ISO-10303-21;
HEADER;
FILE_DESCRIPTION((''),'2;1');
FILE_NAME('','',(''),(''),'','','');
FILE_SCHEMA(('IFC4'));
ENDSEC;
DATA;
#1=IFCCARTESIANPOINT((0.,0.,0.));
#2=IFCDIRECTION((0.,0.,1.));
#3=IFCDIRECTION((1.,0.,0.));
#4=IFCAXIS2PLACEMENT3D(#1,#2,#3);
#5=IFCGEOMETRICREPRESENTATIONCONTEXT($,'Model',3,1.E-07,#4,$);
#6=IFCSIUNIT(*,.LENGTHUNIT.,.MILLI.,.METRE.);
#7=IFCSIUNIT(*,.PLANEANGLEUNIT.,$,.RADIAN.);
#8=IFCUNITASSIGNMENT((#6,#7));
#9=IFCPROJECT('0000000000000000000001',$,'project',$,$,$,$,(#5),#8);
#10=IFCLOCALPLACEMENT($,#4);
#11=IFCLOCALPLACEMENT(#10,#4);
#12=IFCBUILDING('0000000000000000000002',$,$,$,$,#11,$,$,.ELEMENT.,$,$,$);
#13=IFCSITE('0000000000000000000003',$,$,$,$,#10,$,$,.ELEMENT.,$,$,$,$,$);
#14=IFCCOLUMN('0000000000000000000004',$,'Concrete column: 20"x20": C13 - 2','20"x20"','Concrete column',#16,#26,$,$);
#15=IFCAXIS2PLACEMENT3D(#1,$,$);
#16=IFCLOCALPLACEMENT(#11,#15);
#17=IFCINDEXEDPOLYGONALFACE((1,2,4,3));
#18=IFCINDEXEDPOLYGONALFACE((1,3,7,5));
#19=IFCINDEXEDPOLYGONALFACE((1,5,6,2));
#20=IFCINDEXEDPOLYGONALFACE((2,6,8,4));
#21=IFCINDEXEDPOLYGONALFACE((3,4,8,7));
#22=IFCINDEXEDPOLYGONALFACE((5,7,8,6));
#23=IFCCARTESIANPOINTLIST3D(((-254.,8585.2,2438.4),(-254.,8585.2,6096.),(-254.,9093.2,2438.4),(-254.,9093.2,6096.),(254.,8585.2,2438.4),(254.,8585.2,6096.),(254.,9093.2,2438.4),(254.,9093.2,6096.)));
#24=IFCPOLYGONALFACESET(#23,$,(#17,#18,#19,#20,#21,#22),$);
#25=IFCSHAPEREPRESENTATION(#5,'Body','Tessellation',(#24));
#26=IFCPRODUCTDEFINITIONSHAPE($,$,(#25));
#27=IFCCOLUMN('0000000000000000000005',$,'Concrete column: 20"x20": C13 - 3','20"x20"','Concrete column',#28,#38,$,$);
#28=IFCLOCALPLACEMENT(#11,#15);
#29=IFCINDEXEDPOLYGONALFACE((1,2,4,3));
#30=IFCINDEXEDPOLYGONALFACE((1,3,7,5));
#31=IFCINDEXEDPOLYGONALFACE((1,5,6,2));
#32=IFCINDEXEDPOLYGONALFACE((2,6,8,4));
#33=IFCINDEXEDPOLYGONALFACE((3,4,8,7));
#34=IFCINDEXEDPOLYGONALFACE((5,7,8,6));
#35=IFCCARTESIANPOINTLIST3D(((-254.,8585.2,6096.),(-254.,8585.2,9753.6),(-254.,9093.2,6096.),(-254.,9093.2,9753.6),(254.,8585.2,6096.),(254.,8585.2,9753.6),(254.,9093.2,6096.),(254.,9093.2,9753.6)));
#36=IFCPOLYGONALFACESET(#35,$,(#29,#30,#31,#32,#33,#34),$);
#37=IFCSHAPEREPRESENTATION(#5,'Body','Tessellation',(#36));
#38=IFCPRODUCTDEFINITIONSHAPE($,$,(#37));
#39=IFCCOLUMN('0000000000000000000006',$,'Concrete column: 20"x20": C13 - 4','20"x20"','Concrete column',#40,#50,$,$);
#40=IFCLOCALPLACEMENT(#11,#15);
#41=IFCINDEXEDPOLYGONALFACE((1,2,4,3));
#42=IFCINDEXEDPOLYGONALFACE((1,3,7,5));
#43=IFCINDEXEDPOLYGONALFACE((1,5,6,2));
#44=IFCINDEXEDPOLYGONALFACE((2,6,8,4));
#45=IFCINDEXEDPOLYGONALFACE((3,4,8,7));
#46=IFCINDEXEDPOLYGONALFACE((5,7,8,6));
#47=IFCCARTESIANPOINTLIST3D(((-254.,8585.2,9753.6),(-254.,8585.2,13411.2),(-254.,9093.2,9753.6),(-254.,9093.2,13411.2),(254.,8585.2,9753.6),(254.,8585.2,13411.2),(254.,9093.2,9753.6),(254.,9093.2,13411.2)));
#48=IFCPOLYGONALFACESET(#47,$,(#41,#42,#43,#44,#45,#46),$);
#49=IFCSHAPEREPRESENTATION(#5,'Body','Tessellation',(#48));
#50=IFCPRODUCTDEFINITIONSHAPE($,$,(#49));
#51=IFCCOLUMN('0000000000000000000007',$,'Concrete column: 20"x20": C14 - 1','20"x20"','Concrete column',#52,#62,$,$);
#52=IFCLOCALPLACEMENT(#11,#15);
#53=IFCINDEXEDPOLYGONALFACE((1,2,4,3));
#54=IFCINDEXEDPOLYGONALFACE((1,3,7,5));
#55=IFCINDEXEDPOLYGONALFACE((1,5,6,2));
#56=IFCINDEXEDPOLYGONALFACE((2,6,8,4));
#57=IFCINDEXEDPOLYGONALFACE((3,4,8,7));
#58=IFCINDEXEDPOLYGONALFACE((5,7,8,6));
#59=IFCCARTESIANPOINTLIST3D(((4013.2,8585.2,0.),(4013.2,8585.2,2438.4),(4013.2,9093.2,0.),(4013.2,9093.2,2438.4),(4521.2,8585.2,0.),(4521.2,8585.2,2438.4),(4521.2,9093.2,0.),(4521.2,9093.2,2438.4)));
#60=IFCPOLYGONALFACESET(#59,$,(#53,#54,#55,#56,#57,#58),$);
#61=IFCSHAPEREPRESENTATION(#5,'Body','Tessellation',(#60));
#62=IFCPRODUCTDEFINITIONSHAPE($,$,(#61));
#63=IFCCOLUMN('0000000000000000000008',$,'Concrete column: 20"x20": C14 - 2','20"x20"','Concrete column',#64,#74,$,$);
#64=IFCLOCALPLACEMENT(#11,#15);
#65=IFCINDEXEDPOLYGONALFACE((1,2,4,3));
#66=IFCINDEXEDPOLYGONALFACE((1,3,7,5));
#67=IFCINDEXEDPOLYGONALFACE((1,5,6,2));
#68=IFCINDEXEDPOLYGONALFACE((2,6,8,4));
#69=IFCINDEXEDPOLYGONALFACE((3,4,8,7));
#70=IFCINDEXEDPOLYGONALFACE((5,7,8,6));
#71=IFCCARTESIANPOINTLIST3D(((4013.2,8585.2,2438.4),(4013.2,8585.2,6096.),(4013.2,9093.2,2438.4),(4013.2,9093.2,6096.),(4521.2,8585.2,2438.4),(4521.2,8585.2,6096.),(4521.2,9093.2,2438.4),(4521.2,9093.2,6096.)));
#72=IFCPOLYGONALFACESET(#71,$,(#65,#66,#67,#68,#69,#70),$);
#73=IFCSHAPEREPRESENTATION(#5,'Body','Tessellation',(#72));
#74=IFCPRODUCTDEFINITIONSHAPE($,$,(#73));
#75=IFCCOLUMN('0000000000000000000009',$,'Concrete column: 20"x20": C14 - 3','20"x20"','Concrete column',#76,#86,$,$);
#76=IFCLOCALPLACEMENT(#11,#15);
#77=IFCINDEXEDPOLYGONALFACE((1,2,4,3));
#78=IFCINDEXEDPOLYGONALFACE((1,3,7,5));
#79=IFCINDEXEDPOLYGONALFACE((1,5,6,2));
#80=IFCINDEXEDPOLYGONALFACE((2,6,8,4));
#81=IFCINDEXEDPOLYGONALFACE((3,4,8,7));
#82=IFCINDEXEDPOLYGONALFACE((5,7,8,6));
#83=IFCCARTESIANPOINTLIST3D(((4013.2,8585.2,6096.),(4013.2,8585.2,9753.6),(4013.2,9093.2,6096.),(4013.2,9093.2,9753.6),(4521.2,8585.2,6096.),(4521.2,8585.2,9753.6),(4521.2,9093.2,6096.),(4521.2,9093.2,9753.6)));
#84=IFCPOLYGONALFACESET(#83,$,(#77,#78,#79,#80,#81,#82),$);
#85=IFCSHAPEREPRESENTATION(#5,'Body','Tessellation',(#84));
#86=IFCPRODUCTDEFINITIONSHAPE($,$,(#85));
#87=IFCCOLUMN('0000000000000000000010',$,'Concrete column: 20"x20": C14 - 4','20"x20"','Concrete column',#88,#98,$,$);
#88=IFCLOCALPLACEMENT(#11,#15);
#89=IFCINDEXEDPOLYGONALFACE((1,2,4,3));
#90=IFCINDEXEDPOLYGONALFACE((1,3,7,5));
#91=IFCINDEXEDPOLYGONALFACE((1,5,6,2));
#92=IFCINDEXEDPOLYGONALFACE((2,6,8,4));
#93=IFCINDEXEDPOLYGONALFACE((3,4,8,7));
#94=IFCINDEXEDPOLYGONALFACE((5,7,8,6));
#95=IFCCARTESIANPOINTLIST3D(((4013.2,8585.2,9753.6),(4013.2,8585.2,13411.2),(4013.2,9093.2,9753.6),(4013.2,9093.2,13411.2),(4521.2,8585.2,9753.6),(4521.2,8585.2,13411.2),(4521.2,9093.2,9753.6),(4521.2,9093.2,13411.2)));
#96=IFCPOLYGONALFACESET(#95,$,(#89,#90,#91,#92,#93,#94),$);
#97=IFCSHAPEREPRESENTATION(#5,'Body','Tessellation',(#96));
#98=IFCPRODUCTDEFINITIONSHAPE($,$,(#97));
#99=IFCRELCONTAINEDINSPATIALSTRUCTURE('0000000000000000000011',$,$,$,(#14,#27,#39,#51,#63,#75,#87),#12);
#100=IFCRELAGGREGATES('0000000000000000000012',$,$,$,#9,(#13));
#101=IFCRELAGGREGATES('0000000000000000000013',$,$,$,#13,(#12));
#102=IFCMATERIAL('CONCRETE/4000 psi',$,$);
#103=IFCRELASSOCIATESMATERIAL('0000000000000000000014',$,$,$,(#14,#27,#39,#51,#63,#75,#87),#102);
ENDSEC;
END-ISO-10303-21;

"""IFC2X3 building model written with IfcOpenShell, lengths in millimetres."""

from ifc_helpers import new_model, si_unit, frame, origin_with_axes, origin_2d_with_axis, place, context, project, spatial, rectangle, extrude, material, element, save


model = new_model("IFC2X3")

# Units and contexts
model_context = context("Model", 3, precision=1e-07, world=origin_with_axes())
ifc_project = project(units=[si_unit("LENGTHUNIT", "METRE", prefix="MILLI"), si_unit("PLANEANGLEUNIT", "RADIAN")], contexts=[model_context])

# Site, building
site_placement = place(None, origin_with_axes())
site = spatial("IfcSite", under=ifc_project, at=site_placement, CompositionType="ELEMENT")
building_placement = place(site_placement, origin_with_axes())
building = spatial("IfcBuilding", under=site, at=building_placement, CompositionType="ELEMENT")

# Columns
ifc_material = material(Name="CONCRETE/4000 psi")
for number, where, z_axis, x_axis, name in (
    (1, (0.0, 8839.2, 2438.4), (0.0, 0.0, 1.0), (1.0, 0.0, 0.0), "Concrete column: 20\"x20\": C13 - 2"),
    (2, (0.0, 8839.2, 6096.0), (0.0, 0.0, 1.0), (1.0, 0.0, 0.0), "Concrete column: 20\"x20\": C13 - 3"),
    (3, (0.0, 8839.2, 9753.6), (0.0, 0.0, 1.0), (1.0, 0.0, 0.0), "Concrete column: 20\"x20\": C13 - 4"),
):
    element("IfcColumn", number, at=place(building_placement, frame(where, z_axis=z_axis, x_axis=x_axis)), inside=building, material=ifc_material, Name=name, Description="20\"x20\"", ObjectType="Concrete column", context=model_context, shape_type="SweptSolid", body=[
        extrude(rectangle(XDim=508.0, YDim=508.0, at=origin_2d_with_axis()), origin_with_axes(), (0.0, 0.0, 1.0), 3657.6),
    ])
column_1_placement = place(building_placement, frame((4267.2, 8839.2, 0.0), z_axis=(0.0, 0.0, 1.0), x_axis=(1.0, 0.0, 0.0)))
element("IfcColumn", 4, at=column_1_placement, inside=building, material=ifc_material, Name="Concrete column: 20\"x20\": C14 - 1", Description="20\"x20\"", ObjectType="Concrete column", context=model_context, shape_type="SweptSolid", body=[
    extrude(rectangle(XDim=508.0, YDim=508.0, at=origin_2d_with_axis()), origin_with_axes(), (0.0, 0.0, 1.0), 2438.4),
])
for number, where, z_axis, x_axis, name in (
    (5, (4267.2, 8839.2, 2438.4), (0.0, 0.0, 1.0), (1.0, 0.0, 0.0), "Concrete column: 20\"x20\": C14 - 2"),
    (6, (4267.2, 8839.2, 6096.0), (0.0, 0.0, 1.0), (1.0, 0.0, 0.0), "Concrete column: 20\"x20\": C14 - 3"),
    (7, (4267.2, 8839.2, 9753.6), (0.0, 0.0, 1.0), (1.0, 0.0, 0.0), "Concrete column: 20\"x20\": C14 - 4"),
):
    element("IfcColumn", number, at=place(building_placement, frame(where, z_axis=z_axis, x_axis=x_axis)), inside=building, material=ifc_material, Name=name, Description="20\"x20\"", ObjectType="Concrete column", context=model_context, shape_type="SweptSolid", body=[
        extrude(rectangle(XDim=508.0, YDim=508.0, at=origin_2d_with_axis()), origin_with_axes(), (0.0, 0.0, 1.0), 3657.6),
    ])

save(model, "model.ifc")
